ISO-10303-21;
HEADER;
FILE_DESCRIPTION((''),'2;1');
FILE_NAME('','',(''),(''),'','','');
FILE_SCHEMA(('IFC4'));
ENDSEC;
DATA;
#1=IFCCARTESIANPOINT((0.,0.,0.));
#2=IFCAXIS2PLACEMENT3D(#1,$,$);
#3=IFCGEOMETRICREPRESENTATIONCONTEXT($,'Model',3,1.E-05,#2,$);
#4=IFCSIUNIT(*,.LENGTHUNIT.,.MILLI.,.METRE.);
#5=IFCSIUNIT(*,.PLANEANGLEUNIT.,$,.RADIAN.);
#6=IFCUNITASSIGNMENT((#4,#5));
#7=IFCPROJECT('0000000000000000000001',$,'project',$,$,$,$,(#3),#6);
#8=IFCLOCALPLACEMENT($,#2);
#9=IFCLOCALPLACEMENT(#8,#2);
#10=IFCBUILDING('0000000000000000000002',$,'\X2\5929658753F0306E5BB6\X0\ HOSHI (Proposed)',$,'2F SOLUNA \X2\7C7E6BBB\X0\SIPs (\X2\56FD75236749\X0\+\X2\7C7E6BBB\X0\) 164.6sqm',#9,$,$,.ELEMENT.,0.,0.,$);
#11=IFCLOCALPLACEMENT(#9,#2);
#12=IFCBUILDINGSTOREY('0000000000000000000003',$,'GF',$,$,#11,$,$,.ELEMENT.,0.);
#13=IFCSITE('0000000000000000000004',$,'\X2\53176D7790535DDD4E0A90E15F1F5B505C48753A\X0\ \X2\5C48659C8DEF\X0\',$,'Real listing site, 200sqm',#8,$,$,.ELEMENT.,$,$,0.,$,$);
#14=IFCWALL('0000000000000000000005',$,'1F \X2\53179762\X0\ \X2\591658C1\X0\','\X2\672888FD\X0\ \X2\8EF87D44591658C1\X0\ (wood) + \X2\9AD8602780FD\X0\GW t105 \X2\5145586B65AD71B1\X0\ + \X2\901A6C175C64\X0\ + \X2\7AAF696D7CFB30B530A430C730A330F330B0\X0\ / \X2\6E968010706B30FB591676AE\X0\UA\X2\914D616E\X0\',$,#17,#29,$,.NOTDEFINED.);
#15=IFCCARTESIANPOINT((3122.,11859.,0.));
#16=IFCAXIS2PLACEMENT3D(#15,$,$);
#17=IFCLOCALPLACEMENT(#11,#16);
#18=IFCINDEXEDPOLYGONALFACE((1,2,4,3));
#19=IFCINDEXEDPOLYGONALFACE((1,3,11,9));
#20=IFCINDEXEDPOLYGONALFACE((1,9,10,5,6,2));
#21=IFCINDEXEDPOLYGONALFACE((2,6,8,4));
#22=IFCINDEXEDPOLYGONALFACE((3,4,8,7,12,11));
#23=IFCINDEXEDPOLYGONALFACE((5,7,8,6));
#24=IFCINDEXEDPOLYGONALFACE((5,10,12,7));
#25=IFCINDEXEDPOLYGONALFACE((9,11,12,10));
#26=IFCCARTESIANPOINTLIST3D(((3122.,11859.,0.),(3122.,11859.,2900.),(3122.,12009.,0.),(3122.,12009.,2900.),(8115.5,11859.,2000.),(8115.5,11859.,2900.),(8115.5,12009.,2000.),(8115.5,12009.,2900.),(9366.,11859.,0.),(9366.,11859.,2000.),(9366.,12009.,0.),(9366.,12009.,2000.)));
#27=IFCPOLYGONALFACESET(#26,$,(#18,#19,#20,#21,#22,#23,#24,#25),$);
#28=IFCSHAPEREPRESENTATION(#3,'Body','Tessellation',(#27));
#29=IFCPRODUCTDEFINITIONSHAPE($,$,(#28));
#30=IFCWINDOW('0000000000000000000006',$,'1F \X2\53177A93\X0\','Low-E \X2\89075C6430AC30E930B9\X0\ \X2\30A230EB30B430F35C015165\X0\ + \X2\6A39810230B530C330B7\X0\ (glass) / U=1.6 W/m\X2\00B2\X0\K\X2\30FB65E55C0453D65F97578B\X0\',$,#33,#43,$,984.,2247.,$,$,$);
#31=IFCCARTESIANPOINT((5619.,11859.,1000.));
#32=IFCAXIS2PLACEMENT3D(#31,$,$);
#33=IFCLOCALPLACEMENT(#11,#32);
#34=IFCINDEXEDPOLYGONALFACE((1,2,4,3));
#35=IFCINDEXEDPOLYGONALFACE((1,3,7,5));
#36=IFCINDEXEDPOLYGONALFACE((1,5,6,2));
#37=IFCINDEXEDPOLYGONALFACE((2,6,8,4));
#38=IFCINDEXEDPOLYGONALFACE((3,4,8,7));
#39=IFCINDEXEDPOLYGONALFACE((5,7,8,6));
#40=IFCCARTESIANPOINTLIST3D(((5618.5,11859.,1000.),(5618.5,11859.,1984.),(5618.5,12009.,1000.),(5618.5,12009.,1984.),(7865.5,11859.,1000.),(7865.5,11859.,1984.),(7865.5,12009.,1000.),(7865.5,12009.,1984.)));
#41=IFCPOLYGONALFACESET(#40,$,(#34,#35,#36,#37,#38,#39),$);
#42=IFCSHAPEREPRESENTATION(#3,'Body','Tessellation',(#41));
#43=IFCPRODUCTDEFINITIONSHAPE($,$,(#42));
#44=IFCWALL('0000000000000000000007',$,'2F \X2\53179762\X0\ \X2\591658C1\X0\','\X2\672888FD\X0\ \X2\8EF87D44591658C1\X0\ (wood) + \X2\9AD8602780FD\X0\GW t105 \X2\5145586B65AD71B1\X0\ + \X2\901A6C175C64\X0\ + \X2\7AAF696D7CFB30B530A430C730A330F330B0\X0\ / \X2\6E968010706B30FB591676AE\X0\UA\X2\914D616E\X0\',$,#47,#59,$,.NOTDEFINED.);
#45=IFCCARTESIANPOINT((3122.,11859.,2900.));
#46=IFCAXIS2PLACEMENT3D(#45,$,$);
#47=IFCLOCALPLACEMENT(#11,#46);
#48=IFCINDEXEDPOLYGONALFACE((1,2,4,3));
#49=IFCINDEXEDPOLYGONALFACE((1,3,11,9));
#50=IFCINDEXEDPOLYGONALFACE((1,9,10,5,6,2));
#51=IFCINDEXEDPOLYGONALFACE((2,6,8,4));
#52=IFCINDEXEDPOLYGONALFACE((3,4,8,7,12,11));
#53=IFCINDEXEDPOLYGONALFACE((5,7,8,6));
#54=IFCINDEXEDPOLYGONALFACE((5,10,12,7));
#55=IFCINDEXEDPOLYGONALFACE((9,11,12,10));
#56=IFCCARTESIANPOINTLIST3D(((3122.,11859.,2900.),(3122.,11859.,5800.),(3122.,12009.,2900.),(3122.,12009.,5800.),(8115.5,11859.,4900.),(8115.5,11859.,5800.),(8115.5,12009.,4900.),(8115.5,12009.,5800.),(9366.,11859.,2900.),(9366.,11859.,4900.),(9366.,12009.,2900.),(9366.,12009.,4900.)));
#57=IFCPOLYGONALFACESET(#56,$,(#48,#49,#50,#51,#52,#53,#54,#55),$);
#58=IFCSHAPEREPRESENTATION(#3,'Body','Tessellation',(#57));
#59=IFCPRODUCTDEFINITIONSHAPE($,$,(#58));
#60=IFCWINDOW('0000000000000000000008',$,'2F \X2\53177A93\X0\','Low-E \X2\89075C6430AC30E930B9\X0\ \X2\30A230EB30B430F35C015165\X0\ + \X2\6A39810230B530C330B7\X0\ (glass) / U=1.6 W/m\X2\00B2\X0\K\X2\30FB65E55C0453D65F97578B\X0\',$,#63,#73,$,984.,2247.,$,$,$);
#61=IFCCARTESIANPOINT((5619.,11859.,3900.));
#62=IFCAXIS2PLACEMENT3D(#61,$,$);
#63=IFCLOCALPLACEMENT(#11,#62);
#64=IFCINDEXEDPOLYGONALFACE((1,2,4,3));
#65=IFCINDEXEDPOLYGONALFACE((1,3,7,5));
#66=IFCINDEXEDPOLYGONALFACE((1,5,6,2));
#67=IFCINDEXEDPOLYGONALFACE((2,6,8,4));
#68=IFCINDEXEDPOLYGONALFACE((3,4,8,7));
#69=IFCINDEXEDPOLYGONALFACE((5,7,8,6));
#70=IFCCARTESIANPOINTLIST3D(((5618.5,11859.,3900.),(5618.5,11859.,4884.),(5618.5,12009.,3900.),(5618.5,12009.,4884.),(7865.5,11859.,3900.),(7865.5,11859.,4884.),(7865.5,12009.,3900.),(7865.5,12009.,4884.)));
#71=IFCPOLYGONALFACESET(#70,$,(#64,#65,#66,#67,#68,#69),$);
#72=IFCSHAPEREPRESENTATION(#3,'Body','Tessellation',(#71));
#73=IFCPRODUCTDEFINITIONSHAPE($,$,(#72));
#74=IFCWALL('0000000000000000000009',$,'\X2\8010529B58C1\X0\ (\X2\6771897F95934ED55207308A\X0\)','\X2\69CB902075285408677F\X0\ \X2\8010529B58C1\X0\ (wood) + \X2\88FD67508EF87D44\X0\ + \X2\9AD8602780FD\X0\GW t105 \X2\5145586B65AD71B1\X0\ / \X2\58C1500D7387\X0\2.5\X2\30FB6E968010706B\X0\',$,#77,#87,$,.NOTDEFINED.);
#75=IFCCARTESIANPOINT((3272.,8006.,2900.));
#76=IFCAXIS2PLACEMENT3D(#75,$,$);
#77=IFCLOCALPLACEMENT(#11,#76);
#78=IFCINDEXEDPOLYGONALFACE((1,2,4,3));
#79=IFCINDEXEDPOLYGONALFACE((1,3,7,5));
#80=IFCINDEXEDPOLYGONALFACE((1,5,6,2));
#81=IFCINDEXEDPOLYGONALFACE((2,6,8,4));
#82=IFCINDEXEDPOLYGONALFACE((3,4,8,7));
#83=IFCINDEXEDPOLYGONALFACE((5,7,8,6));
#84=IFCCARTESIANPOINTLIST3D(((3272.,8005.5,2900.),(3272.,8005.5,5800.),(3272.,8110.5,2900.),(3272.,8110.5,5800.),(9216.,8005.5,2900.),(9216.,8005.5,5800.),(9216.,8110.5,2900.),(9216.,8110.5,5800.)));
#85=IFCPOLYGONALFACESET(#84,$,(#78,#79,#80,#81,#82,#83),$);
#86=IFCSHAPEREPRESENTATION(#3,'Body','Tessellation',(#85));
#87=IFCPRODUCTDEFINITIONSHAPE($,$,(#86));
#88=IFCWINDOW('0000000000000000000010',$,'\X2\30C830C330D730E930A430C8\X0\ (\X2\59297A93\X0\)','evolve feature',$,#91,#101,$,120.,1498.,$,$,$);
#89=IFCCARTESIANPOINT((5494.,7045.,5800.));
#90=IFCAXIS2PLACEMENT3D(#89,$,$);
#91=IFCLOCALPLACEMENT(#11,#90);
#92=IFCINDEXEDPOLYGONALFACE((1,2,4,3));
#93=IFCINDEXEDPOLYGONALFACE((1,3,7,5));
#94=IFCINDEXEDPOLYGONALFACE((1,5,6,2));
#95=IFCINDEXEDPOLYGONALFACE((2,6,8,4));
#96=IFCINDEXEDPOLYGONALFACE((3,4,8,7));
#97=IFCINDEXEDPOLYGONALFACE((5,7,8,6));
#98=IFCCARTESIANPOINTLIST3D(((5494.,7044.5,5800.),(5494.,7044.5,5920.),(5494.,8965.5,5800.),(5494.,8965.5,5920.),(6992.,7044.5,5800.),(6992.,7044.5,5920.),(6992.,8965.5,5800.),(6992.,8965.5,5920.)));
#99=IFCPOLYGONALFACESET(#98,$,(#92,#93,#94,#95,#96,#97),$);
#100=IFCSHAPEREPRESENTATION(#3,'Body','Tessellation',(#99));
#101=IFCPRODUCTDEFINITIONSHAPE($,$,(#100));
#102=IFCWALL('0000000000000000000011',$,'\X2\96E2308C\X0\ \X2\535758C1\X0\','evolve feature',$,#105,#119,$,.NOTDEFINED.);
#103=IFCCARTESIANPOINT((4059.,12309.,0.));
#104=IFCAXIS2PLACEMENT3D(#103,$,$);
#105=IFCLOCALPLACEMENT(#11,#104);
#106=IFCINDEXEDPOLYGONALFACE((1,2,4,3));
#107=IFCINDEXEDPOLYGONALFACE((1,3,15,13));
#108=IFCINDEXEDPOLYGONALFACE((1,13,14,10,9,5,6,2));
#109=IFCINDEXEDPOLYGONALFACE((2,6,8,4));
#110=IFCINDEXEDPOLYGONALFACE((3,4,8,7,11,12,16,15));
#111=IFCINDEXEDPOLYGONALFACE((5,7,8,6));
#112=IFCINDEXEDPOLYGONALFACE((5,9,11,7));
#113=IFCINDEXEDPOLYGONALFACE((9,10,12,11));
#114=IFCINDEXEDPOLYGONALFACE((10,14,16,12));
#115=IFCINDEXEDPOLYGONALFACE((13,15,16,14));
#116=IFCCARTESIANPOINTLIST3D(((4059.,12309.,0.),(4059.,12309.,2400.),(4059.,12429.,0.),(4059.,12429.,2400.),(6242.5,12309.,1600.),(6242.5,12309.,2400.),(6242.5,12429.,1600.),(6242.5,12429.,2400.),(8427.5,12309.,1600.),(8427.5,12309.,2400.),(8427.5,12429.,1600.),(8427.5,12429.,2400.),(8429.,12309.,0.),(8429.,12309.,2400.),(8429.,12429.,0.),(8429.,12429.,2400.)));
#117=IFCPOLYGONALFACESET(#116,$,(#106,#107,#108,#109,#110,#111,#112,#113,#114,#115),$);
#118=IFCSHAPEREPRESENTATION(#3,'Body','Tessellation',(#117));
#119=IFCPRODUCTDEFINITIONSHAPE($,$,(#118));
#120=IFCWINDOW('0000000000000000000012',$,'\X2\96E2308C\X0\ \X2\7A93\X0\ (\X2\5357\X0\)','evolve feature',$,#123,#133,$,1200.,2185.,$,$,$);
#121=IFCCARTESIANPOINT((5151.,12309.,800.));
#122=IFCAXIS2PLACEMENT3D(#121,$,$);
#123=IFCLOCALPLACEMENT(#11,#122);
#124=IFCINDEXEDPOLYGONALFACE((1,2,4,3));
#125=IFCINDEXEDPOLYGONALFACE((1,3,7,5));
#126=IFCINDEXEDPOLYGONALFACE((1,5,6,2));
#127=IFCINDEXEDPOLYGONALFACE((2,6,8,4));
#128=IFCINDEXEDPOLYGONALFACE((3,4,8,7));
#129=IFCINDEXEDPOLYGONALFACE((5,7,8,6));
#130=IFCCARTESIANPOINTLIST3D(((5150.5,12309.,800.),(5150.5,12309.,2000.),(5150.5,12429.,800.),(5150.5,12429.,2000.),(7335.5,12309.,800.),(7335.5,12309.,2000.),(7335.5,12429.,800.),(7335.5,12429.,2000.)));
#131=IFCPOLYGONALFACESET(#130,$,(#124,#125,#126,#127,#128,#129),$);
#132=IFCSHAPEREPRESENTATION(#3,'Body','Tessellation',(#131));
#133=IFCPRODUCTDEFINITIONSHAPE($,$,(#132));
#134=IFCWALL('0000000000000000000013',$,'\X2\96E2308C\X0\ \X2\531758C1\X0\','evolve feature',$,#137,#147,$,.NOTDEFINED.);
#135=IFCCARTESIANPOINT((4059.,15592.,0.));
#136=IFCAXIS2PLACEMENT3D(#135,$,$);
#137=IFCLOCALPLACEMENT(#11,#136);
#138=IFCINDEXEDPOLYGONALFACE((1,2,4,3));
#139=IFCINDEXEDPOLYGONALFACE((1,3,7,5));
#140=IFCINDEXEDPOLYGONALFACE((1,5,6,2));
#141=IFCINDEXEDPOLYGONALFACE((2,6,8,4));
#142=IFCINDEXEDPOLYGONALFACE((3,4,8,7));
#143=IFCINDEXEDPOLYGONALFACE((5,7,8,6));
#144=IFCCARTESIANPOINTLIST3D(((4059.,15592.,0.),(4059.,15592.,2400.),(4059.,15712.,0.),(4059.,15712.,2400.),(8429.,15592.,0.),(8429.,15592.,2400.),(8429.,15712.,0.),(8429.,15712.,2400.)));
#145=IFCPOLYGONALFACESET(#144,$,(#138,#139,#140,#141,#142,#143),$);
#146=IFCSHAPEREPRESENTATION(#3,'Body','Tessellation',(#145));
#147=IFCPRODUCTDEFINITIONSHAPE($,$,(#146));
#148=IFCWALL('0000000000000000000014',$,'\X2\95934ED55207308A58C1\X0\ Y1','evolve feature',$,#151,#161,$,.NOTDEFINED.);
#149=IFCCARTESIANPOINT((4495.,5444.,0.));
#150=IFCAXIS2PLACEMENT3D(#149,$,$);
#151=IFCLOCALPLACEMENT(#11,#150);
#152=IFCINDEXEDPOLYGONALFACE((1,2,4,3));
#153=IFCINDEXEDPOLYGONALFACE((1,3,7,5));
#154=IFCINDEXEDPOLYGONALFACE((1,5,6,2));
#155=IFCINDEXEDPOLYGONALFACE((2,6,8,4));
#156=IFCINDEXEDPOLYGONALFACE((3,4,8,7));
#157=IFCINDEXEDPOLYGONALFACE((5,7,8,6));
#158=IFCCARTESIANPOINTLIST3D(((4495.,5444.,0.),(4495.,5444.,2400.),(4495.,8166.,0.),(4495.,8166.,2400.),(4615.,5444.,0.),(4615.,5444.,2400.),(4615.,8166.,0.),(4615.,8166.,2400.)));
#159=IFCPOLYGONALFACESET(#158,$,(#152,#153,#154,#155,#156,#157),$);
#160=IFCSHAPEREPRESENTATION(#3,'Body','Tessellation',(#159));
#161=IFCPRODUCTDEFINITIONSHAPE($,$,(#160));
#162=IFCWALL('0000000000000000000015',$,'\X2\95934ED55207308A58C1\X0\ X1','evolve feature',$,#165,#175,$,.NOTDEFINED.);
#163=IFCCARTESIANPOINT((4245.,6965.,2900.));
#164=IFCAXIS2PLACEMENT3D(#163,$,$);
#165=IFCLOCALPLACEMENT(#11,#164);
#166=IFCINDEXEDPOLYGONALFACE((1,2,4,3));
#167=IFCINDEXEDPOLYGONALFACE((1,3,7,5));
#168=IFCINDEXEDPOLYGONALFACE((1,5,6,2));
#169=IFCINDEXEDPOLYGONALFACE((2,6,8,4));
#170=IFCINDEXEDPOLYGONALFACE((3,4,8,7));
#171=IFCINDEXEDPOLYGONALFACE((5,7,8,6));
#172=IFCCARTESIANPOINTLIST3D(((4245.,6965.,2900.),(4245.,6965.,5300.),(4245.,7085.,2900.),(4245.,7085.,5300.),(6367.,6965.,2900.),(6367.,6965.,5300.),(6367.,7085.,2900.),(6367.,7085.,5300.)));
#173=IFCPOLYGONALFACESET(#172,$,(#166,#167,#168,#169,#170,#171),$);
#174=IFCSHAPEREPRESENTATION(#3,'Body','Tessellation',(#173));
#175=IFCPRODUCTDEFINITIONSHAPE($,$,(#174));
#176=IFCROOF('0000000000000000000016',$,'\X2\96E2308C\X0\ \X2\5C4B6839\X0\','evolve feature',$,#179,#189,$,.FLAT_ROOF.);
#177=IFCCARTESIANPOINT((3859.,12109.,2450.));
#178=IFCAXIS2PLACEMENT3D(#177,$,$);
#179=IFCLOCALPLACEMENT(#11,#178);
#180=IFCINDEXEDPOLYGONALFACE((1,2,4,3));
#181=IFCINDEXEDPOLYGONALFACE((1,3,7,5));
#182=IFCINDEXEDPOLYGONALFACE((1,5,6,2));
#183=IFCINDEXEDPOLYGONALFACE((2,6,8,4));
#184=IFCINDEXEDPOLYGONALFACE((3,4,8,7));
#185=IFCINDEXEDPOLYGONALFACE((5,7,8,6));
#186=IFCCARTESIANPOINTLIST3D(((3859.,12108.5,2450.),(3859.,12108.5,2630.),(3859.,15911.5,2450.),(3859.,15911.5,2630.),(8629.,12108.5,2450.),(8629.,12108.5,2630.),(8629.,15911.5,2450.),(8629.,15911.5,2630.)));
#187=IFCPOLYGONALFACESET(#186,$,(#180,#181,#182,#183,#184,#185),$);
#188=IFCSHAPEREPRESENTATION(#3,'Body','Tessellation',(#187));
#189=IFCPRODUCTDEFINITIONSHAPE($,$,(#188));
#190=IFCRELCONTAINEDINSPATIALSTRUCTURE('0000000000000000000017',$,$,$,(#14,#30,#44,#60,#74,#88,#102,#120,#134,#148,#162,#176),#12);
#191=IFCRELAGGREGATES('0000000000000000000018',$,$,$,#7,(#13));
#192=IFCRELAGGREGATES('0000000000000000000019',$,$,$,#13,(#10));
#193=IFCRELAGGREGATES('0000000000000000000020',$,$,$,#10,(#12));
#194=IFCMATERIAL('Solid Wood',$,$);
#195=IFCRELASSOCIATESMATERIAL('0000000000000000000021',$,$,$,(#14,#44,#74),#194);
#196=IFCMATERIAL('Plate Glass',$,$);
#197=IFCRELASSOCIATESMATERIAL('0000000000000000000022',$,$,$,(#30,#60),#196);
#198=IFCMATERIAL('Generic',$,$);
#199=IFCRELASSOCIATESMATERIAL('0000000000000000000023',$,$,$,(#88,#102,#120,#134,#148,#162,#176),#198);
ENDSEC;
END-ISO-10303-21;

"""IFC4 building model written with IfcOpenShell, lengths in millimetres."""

from ifc_helpers import new_model, si_unit, frame, frame_2d, origin, place, context, project, spatial, rectangle, extrude, material, element, fill, save


model = new_model("IFC4")

# Units and contexts
model_context = context("Model", 3, precision=1e-05, world=origin())
ifc_project = project(units=[si_unit("LENGTHUNIT", "METRE", prefix="MILLI"), si_unit("PLANEANGLEUNIT", "RADIAN")], contexts=[model_context])

# Site, building, storey
site_placement = place(None, origin())
site = spatial("IfcSite", under=ifc_project, at=site_placement, Name="北海道川上郡弟子屈町 屈斜路", ObjectType="Real listing site, 200sqm", CompositionType="ELEMENT", RefElevation=0.0)
building_placement = place(site_placement, origin())
building = spatial("IfcBuilding", under=site, at=building_placement, Name="天文台の家 HOSHI (Proposed)", ObjectType="2F SOLUNA 籾殻SIPs (国産杉+籾殻) 164.6sqm", CompositionType="ELEMENT", ElevationOfRefHeight=0.0, ElevationOfTerrain=0.0)
storey_placement = place(building_placement, origin())
storey = spatial("IfcBuildingStorey", under=building, at=storey_placement, Name="GF", CompositionType="ELEMENT", Elevation=0.0)

# Shared definitions
ifc_material_1 = material(Name="Generic")

# Wall, opening, window
ifc_material_2 = material(Name="Solid Wood")
wall_1_placement = place(storey_placement, frame((3122.0, 11859.0, 0.0)))
wall_1 = element("IfcWall", 1, at=wall_1_placement, inside=storey, material=ifc_material_2, Name="1F 北面 外壁", Description="木製 軸組外壁 (wood) + 高性能GW t105 充填断熱 + 通気層 + 窯業系サイディング / 準耐火・外皮UA配慮", PredefinedType="NOTDEFINED", context=model_context, shape_type="SweptSolid", body=[
    extrude(rectangle(XDim=6244.0, YDim=150.0, at=frame_2d((3122.0, 75.0))), frame((3122.0, 11859.0, 0.0)), (0.0, 0.0, 1.0), 2900.0),
])
opening_1_placement = place(storey_placement, frame((5619.0, 11859.0, 1000.0)))
opening_1 = element("IfcOpeningElement", 2, at=opening_1_placement, cuts=wall_1, PredefinedType="NOTDEFINED", context=model_context, shape_type="SweptSolid", body=[
    extrude(rectangle(XDim=2247.0, YDim=150.0, at=frame_2d((1123.0, 75.0))), frame((5619.0, 11859.0, 1000.0)), (0.0, 0.0, 1.0), 984.0),
])
ifc_material_3 = material(Name="Plate Glass")
window_1_placement = place(storey_placement, frame((5619.0, 11859.0, 1000.0)))
window_1 = element("IfcWindow", 3, at=window_1_placement, inside=storey, material=ifc_material_3, Name="1F 北窓", Description="Low-E 複層ガラス アルゴン封入 + 樹脂サッシ (glass) / U=1.6 W/m²K・日射取得型", OverallHeight=984.0, OverallWidth=2247.0, context=model_context, shape_type="SweptSolid", body=[
    extrude(rectangle(XDim=2247.0, YDim=150.0, at=frame_2d((1123.0, 75.0))), frame((5619.0, 11859.0, 1000.0)), (0.0, 0.0, 1.0), 984.0),
])
fill(opening_1, window_1)

# Wall, opening, window
wall_2_placement = place(storey_placement, frame((3122.0, 11859.0, 2900.0)))
wall_2 = element("IfcWall", 4, at=wall_2_placement, inside=storey, material=ifc_material_2, Name="2F 北面 外壁", Description="木製 軸組外壁 (wood) + 高性能GW t105 充填断熱 + 通気層 + 窯業系サイディング / 準耐火・外皮UA配慮", PredefinedType="NOTDEFINED", context=model_context, shape_type="SweptSolid", body=[
    extrude(rectangle(XDim=6244.0, YDim=150.0, at=frame_2d((3122.0, 75.0))), frame((3122.0, 11859.0, 2900.0)), (0.0, 0.0, 1.0), 2900.0),
])
opening_2_placement = place(storey_placement, frame((5619.0, 11859.0, 3900.0)))
opening_2 = element("IfcOpeningElement", 5, at=opening_2_placement, cuts=wall_2, PredefinedType="NOTDEFINED", context=model_context, shape_type="SweptSolid", body=[
    extrude(rectangle(XDim=2247.0, YDim=150.0, at=frame_2d((1123.0, 75.0))), frame((5619.0, 11859.0, 3900.0)), (0.0, 0.0, 1.0), 984.0),
])
window_2_placement = place(storey_placement, frame((5619.0, 11859.0, 3900.0)))
window_2 = element("IfcWindow", 6, at=window_2_placement, inside=storey, material=ifc_material_3, Name="2F 北窓", Description="Low-E 複層ガラス アルゴン封入 + 樹脂サッシ (glass) / U=1.6 W/m²K・日射取得型", OverallHeight=984.0, OverallWidth=2247.0, context=model_context, shape_type="SweptSolid", body=[
    extrude(rectangle(XDim=2247.0, YDim=150.0, at=frame_2d((1123.0, 75.0))), frame((5619.0, 11859.0, 3900.0)), (0.0, 0.0, 1.0), 984.0),
])
fill(opening_2, window_2)

# Wall
wall_3_placement = place(storey_placement, frame((3272.0, 8006.0, 2900.0)))
element("IfcWall", 7, at=wall_3_placement, inside=storey, material=ifc_material_2, Name="耐力壁 (東西間仕切り)", Description="構造用合板 耐力壁 (wood) + 製材軸組 + 高性能GW t105 充填断熱 / 壁倍率2.5・準耐火", PredefinedType="NOTDEFINED", context=model_context, shape_type="SweptSolid", body=[
    extrude(rectangle(XDim=5944.0, YDim=105.0, at=frame_2d((2972.0, 52.0))), frame((3272.0, 8006.0, 2900.0)), (0.0, 0.0, 1.0), 2900.0),
])

# Window
window_3_placement = place(storey_placement, frame((5494.0, 7045.0, 5800.0)))
element("IfcWindow", 8, at=window_3_placement, inside=storey, material=ifc_material_1, Name="トップライト (天窓)", Description="evolve feature", OverallHeight=120.0, OverallWidth=1498.0, context=model_context, shape_type="SweptSolid", body=[
    extrude(rectangle(XDim=1498.0, YDim=1921.0, at=frame_2d((749.0, 960.0))), frame((5494.0, 7045.0, 5800.0)), (0.0, 0.0, 1.0), 120.0),
])

# Wall, opening, window
wall_4_placement = place(storey_placement, frame((4059.0, 12309.0, 0.0)))
wall_4 = element("IfcWall", 9, at=wall_4_placement, inside=storey, material=ifc_material_1, Name="離れ 南壁", Description="evolve feature", PredefinedType="NOTDEFINED", context=model_context, shape_type="SweptSolid", body=[
    extrude(rectangle(XDim=4370.0, YDim=120.0, at=frame_2d((2185.0, 60.0))), frame((4059.0, 12309.0, 0.0)), (0.0, 0.0, 1.0), 2400.0),
])
opening_3_placement = place(storey_placement, frame((5151.0, 12309.0, 800.0)))
opening_3 = element("IfcOpeningElement", 10, at=opening_3_placement, cuts=wall_4, PredefinedType="NOTDEFINED", context=model_context, shape_type="SweptSolid", body=[
    extrude(rectangle(XDim=2185.0, YDim=120.0, at=frame_2d((1092.0, 60.0))), frame((5151.0, 12309.0, 800.0)), (0.0, 0.0, 1.0), 1200.0),
])
window_4_placement = place(storey_placement, frame((5151.0, 12309.0, 800.0)))
window_4 = element("IfcWindow", 11, at=window_4_placement, inside=storey, material=ifc_material_1, Name="離れ 窓 (南)", Description="evolve feature", OverallHeight=1200.0, OverallWidth=2185.0, context=model_context, shape_type="SweptSolid", body=[
    extrude(rectangle(XDim=2185.0, YDim=120.0, at=frame_2d((1092.0, 60.0))), frame((5151.0, 12309.0, 800.0)), (0.0, 0.0, 1.0), 1200.0),
])
fill(opening_3, window_4)

# Walls
wall_5_placement = place(storey_placement, frame((4059.0, 15592.0, 0.0)))
element("IfcWall", 12, at=wall_5_placement, inside=storey, material=ifc_material_1, Name="離れ 北壁", Description="evolve feature", PredefinedType="NOTDEFINED", context=model_context, shape_type="SweptSolid", body=[
    extrude(rectangle(XDim=4370.0, YDim=120.0, at=frame_2d((2185.0, 60.0))), frame((4059.0, 15592.0, 0.0)), (0.0, 0.0, 1.0), 2400.0),
])
wall_6_placement = place(storey_placement, frame((4495.0, 5444.0, 0.0)))
element("IfcWall", 13, at=wall_6_placement, inside=storey, material=ifc_material_1, Name="間仕切り壁 Y1", Description="evolve feature", PredefinedType="NOTDEFINED", context=model_context, shape_type="SweptSolid", body=[
    extrude(rectangle(XDim=120.0, YDim=2722.0, at=frame_2d((60.0, 1361.0))), frame((4495.0, 5444.0, 0.0)), (0.0, 0.0, 1.0), 2400.0),
])
wall_7_placement = place(storey_placement, frame((4245.0, 6965.0, 2900.0)))
element("IfcWall", 14, at=wall_7_placement, inside=storey, material=ifc_material_1, Name="間仕切り壁 X1", Description="evolve feature", PredefinedType="NOTDEFINED", context=model_context, shape_type="SweptSolid", body=[
    extrude(rectangle(XDim=2122.0, YDim=120.0, at=frame_2d((1061.0, 60.0))), frame((4245.0, 6965.0, 2900.0)), (0.0, 0.0, 1.0), 2400.0),
])

# Roof
roof_placement = place(storey_placement, frame((3859.0, 12109.0, 2450.0)))
element("IfcRoof", 15, at=roof_placement, inside=storey, material=ifc_material_1, Name="離れ 屋根", Description="evolve feature", PredefinedType="FLAT_ROOF", context=model_context, shape_type="SweptSolid", body=[
    extrude(rectangle(XDim=4770.0, YDim=3803.0, at=frame_2d((2385.0, 1901.0))), frame((3859.0, 12109.0, 2450.0)), (0.0, 0.0, 1.0), 180.0),
])

save(model, "model.ifc")
